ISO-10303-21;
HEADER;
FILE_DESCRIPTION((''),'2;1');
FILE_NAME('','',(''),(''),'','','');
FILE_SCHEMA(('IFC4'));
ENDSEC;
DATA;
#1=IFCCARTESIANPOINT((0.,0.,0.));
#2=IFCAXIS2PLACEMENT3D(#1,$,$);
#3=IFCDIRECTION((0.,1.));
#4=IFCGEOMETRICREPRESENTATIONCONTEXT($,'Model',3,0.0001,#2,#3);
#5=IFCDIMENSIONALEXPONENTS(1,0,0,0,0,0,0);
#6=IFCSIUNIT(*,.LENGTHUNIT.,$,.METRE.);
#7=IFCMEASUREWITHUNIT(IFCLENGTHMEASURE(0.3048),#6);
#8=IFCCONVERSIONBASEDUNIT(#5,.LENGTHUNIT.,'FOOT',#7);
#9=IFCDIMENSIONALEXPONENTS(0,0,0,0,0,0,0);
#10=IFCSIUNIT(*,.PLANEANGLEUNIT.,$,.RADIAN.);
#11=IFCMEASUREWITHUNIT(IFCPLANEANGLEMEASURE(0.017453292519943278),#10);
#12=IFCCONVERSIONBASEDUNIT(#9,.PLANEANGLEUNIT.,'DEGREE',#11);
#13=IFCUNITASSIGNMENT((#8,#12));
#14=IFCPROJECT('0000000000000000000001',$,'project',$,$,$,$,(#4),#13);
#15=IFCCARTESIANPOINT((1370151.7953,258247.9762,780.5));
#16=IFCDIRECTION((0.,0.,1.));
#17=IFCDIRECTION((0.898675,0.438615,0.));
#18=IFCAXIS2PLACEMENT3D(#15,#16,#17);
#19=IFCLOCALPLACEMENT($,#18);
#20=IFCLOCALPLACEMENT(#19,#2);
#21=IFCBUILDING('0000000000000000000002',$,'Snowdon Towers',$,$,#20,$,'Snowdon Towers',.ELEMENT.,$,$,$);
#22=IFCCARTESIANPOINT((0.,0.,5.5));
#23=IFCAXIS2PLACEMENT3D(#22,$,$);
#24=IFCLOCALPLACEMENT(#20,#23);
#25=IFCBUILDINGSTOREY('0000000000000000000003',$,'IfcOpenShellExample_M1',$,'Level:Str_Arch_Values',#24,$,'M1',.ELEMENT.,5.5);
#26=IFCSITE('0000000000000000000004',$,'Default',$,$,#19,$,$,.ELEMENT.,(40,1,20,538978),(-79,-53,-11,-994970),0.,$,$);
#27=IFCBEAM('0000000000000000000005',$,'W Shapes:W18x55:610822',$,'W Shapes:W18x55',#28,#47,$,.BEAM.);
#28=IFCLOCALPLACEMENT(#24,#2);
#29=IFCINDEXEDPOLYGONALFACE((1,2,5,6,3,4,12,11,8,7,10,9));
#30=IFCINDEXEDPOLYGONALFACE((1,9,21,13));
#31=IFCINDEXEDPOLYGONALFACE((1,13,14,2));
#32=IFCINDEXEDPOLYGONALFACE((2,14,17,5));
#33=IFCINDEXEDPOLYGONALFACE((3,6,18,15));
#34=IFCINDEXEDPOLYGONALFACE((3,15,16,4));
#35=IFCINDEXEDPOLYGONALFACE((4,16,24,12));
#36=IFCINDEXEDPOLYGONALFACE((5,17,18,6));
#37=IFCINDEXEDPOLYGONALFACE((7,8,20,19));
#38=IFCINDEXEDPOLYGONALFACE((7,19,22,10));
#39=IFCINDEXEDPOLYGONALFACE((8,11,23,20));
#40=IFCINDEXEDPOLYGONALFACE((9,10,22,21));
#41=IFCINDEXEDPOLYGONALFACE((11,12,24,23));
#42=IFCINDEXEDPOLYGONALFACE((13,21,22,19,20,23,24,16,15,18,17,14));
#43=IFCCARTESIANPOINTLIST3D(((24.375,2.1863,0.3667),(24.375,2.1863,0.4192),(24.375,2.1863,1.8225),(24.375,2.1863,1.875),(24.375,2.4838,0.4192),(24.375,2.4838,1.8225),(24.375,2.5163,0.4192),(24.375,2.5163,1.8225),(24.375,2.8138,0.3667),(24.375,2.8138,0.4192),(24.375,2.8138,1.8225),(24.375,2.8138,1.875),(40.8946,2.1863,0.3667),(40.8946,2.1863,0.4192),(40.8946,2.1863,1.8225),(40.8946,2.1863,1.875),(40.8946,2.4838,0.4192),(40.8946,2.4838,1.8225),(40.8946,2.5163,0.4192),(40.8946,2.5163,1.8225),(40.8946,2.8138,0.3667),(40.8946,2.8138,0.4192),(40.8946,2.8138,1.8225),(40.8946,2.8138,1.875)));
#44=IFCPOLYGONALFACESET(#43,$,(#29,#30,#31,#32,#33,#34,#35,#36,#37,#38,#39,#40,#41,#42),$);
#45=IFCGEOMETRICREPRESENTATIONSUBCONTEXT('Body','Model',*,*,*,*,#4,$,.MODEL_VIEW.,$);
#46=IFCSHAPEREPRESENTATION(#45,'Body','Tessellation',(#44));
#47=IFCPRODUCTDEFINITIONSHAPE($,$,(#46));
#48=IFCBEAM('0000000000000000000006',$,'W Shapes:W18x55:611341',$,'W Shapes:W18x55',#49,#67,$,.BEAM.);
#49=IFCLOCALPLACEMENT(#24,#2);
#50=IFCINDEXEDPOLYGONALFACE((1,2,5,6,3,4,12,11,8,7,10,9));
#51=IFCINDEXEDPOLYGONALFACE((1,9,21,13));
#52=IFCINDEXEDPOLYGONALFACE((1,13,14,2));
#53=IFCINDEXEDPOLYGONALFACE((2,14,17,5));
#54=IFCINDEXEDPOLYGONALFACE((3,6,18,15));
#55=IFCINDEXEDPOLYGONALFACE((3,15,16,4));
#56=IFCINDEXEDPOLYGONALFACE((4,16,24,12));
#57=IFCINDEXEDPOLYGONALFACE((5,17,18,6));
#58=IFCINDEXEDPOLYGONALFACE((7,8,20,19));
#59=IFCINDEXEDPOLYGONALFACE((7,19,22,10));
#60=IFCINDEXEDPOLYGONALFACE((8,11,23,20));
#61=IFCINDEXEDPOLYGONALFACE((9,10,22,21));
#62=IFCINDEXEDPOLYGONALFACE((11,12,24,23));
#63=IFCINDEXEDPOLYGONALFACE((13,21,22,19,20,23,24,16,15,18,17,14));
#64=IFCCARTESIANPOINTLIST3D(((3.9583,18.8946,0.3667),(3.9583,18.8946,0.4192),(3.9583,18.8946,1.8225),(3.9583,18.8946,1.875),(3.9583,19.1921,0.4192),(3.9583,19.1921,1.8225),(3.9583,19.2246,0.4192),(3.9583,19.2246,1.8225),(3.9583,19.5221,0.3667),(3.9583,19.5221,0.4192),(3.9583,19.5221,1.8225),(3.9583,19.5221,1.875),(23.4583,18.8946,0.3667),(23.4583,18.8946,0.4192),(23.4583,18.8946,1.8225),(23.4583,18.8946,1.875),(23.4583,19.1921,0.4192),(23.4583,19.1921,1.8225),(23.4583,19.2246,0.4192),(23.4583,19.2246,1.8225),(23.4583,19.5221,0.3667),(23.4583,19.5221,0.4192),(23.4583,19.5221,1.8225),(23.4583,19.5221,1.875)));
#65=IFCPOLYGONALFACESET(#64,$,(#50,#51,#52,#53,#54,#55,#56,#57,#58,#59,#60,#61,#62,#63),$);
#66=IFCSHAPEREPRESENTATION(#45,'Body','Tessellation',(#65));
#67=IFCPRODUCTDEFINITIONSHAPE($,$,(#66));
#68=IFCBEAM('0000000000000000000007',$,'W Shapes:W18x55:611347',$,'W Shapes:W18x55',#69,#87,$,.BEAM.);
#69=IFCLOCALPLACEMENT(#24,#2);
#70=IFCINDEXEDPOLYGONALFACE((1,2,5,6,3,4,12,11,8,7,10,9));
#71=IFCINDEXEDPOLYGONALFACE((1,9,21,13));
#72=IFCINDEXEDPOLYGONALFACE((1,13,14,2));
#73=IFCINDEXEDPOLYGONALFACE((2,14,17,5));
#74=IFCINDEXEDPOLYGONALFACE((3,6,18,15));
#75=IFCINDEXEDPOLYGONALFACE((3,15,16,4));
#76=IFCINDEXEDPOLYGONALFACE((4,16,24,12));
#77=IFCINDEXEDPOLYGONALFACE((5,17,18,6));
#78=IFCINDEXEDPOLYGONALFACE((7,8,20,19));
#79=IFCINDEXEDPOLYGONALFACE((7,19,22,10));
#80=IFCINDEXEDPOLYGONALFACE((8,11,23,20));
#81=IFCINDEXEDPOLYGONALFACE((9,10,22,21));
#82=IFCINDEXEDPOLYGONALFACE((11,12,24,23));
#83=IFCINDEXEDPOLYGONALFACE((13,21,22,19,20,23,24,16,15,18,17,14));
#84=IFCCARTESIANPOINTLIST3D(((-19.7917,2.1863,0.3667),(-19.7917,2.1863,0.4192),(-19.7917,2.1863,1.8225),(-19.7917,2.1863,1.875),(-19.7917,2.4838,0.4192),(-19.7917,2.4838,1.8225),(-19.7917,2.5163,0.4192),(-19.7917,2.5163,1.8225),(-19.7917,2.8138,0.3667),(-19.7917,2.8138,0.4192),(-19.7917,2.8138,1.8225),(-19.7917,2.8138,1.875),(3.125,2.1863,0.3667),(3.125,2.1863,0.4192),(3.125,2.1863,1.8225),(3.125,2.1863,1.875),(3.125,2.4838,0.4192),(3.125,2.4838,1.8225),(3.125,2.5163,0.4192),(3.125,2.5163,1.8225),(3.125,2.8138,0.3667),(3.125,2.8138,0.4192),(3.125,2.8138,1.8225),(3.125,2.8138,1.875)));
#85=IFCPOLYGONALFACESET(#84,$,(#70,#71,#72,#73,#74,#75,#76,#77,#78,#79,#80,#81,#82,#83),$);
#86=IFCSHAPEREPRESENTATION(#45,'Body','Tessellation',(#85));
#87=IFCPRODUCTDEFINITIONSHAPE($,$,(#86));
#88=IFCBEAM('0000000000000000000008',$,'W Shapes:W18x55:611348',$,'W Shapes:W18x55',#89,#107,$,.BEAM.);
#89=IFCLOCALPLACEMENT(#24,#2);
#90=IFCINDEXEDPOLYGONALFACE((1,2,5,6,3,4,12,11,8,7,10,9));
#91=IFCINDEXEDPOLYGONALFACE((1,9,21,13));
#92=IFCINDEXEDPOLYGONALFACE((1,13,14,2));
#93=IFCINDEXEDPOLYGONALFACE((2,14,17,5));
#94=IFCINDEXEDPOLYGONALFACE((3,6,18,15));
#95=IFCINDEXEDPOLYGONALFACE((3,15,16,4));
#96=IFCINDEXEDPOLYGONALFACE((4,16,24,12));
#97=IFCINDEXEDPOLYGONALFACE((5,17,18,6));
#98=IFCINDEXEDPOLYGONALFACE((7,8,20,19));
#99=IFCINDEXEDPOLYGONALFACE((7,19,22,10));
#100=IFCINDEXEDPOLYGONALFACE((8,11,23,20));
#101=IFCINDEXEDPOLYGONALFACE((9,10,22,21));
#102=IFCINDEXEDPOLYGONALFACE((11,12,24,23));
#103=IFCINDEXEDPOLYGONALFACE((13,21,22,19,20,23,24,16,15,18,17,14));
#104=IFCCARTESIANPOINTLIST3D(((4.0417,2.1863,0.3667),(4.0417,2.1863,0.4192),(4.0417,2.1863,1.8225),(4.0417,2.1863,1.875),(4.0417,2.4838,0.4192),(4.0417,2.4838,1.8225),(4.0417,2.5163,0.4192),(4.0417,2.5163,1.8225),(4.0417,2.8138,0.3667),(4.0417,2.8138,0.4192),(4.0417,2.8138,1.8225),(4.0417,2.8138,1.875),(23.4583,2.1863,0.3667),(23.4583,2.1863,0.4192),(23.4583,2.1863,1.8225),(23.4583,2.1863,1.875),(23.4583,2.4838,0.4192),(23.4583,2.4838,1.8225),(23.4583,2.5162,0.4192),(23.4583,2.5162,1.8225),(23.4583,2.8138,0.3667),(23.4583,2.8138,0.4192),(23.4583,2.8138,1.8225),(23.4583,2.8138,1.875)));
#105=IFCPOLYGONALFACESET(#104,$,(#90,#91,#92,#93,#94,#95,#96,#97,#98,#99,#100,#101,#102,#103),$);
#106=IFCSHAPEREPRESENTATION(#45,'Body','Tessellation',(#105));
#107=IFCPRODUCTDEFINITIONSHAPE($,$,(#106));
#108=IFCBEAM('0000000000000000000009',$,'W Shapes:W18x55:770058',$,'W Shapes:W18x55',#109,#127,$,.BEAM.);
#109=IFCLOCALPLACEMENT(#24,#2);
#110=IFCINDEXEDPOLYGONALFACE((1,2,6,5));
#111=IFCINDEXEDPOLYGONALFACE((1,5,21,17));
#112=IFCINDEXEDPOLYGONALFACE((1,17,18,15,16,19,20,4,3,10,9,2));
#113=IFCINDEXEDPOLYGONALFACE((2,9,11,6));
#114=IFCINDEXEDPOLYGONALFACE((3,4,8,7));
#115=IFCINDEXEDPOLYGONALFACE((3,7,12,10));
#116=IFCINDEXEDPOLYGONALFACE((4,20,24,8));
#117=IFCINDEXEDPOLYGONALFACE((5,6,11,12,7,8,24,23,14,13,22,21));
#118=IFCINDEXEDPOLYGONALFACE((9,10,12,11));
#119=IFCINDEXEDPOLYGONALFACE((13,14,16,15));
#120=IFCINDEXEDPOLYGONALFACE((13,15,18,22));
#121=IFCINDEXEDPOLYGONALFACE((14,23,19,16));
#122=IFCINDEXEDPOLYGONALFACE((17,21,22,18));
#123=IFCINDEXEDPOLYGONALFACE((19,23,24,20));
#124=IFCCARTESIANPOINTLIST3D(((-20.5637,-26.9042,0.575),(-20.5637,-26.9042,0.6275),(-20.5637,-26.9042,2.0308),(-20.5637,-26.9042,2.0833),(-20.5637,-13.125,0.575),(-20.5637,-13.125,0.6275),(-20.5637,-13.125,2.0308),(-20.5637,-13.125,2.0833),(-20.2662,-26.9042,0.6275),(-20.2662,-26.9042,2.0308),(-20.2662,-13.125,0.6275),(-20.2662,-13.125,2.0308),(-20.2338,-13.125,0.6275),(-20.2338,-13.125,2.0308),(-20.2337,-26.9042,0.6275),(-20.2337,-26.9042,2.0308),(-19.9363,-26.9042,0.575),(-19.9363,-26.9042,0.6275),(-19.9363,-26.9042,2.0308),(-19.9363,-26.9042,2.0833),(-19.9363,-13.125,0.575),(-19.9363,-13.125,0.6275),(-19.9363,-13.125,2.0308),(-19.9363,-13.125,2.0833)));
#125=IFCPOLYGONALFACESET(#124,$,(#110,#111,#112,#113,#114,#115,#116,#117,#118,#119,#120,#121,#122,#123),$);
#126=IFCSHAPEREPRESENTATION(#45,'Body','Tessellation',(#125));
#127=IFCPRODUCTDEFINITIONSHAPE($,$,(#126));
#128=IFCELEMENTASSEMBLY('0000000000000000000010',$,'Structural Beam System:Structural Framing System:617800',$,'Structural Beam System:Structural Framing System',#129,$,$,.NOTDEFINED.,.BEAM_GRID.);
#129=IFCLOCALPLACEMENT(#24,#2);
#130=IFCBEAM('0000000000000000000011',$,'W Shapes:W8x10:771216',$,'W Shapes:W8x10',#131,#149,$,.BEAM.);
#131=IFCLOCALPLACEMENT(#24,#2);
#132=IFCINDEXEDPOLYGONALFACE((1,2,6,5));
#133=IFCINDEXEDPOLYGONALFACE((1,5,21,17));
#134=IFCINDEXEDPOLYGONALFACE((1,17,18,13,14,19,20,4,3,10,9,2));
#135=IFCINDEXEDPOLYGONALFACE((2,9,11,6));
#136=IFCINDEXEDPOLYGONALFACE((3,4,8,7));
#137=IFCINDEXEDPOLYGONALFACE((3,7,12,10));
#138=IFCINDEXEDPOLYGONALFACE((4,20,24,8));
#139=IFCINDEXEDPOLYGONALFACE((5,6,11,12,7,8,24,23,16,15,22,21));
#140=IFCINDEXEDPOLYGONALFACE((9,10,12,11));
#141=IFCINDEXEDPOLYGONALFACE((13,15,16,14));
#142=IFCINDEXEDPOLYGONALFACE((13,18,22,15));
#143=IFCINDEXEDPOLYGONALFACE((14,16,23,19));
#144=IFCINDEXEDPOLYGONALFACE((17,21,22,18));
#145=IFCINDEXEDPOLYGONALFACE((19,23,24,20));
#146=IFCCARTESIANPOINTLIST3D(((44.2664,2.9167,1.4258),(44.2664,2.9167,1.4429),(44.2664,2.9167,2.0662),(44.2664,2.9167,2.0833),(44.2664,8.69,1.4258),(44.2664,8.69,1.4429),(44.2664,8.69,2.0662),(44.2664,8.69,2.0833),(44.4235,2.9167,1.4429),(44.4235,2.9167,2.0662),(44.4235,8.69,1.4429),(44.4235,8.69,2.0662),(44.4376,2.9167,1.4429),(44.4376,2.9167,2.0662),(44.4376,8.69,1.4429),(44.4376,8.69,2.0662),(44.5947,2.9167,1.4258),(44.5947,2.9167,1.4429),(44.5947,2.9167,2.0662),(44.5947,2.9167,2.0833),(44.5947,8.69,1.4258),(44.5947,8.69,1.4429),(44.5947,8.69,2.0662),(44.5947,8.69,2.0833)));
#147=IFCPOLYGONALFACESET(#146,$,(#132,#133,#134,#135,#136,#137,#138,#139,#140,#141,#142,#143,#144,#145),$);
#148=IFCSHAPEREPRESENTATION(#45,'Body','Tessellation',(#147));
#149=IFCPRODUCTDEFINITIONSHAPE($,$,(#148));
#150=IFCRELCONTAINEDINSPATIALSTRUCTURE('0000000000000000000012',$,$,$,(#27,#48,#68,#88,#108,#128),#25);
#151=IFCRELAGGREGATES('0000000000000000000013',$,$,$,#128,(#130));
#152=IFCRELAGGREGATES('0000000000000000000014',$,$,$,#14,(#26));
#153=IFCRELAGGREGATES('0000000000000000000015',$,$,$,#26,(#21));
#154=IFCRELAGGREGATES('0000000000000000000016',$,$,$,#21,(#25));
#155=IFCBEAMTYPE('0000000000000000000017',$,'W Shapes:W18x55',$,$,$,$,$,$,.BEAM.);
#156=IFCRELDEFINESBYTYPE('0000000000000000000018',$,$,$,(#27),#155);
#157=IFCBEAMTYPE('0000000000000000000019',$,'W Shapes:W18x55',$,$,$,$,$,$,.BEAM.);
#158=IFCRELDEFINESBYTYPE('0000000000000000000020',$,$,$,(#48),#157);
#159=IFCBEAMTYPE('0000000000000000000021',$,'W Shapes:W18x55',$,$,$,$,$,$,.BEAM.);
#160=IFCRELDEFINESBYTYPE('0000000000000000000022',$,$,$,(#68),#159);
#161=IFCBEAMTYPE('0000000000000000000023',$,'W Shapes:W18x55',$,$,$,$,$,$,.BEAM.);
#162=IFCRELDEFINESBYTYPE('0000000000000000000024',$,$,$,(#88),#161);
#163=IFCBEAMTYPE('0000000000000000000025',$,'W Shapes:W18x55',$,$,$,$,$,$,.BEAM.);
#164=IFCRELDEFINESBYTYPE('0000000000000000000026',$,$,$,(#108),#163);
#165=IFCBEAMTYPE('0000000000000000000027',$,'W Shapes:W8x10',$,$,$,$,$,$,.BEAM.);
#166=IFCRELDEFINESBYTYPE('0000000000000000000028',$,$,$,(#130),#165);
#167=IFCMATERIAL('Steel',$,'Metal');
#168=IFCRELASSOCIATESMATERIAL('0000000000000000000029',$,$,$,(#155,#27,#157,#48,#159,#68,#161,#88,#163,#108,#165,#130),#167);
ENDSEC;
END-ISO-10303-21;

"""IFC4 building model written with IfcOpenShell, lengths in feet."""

from ifc_helpers import new_model, entity, si_unit, converted_unit, direction, frame, origin, place, context, subcontext, project, spatial, indexed_curve, outline, extrude, source, transform, mapped, material, type_object, type_shapes, element, aggregate, save


model = new_model("IFC4")

# Units and contexts
model_context = context("Model", 3, precision=0.0001, world=origin(), true_north=direction((0.0, 1.0)))
body_context = subcontext(model_context, "Body", "Model", "MODEL_VIEW")
ifc_project = project(units=[converted_unit("LENGTHUNIT", "FOOT", entity("IfcLengthMeasure", 0.3048), si_unit("LENGTHUNIT", "METRE"), dimensions=[1, 0, 0, 0, 0, 0, 0]), converted_unit("PLANEANGLEUNIT", "DEGREE", entity("IfcPlaneAngleMeasure", 0.017453292519943278), si_unit("PLANEANGLEUNIT", "RADIAN"), dimensions=[0, 0, 0, 0, 0, 0, 0])], contexts=[model_context])

# Site, building, storey
site_placement = place(None, frame((1370151.7953, 258247.9762, 780.5), z_axis=(0.0, 0.0, 1.0), x_axis=(0.898675, 0.438615, 0.0)))
site = spatial("IfcSite", under=ifc_project, at=site_placement, Name="Default", CompositionType="ELEMENT", RefLatitude=(40, 1, 20, 538978), RefLongitude=(-79, -53, -11, -994970), RefElevation=0.0)
building_placement = place(site_placement, origin())
building = spatial("IfcBuilding", under=site, at=building_placement, Name="Snowdon Towers", LongName="Snowdon Towers", CompositionType="ELEMENT")
storey_placement = place(building_placement, frame((0.0, 0.0, 5.5)))
storey = spatial("IfcBuildingStorey", under=building, at=storey_placement, Name="IfcOpenShellExample_M1", ObjectType="Level:Str_Arch_Values", LongName="M1", CompositionType="ELEMENT", Elevation=5.5)

# Beams
ifc_material_1 = material(Name="Steel", Category="Metal")
beam_type_1 = type_object("IfcBeamType", Name="W Shapes:W18x55", PredefinedType="BEAM", material=ifc_material_1)
shared_shape_1 = source(origin(), body_context, "Body", "SweptSolid", [
    extrude(outline(indexed_curve([(-0.3138, -0.7017), (-0.3138, -0.7542), (0.3138, -0.7542), (0.3138, -0.7017), (0.0162, -0.7017), (0.0162, 0.7017), (0.3138, 0.7017), (0.3138, 0.7542), (-0.3137, 0.7542), (-0.3137, 0.7017), (-0.0163, 0.7017), (-0.0163, -0.7017), (-0.3138, -0.7017)], self_intersect=False)), frame((-8.2083, 0.0, 0.0), z_axis=(-1.0, 0.0, 0.0), x_axis=(0.0, -1.0, 0.0)), (0.0, 0.0, -1.0), 16.5196),
])
type_shapes(beam_type_1, [shared_shape_1])
beam_1_placement = place(storey_placement, frame((32.5833, 2.5, 1.1208)))
element("IfcBeam", 1, at=beam_1_placement, inside=storey, type_object=beam_type_1, material=ifc_material_1, Name="W Shapes:W18x55:610822", ObjectType="W Shapes:W18x55", PredefinedType="BEAM", context=body_context, shape_type="MappedRepresentation", body=[
    mapped(shared_shape_1, transform((0.0, 0.0, 0.0), scale=1.0)),
])
beam_type_2 = type_object("IfcBeamType", Name="W Shapes:W18x55", PredefinedType="BEAM", material=ifc_material_1)
shared_shape_2 = source(origin(), body_context, "Body", "SweptSolid", [
    extrude(outline(indexed_curve([(-0.3138, -0.7017), (-0.3138, -0.7542), (0.3138, -0.7542), (0.3138, -0.7017), (0.0162, -0.7017), (0.0162, 0.7017), (0.3138, 0.7017), (0.3138, 0.7542), (-0.3137, 0.7542), (-0.3137, 0.7017), (-0.0163, 0.7017), (-0.0163, -0.7017), (-0.3138, -0.7017)], self_intersect=False)), frame((-9.75, 0.0, 0.0), z_axis=(-1.0, 0.0, 0.0), x_axis=(0.0, -1.0, 0.0)), (0.0, 0.0, -1.0), 19.5),
])
type_shapes(beam_type_2, [shared_shape_2])
beam_2_placement = place(storey_placement, frame((13.7083, 19.2083, 1.1208)))
element("IfcBeam", 2, at=beam_2_placement, inside=storey, type_object=beam_type_2, material=ifc_material_1, Name="W Shapes:W18x55:611341", ObjectType="W Shapes:W18x55", PredefinedType="BEAM", context=body_context, shape_type="MappedRepresentation", body=[
    mapped(shared_shape_2, transform((0.0, 0.0, 0.0), scale=1.0)),
])
beam_type_3 = type_object("IfcBeamType", Name="W Shapes:W18x55", PredefinedType="BEAM", material=ifc_material_1)
shared_shape_3 = source(origin(), body_context, "Body", "SweptSolid", [
    extrude(outline(indexed_curve([(-0.3138, -0.7017), (-0.3138, -0.7542), (0.3138, -0.7542), (0.3138, -0.7017), (0.0162, -0.7017), (0.0162, 0.7017), (0.3138, 0.7017), (0.3138, 0.7542), (-0.3137, 0.7542), (-0.3137, 0.7017), (-0.0163, 0.7017), (-0.0163, -0.7017), (-0.3138, -0.7017)], self_intersect=False)), frame((-11.5417, 0.0, 0.0), z_axis=(-1.0, 0.0, 0.0), x_axis=(0.0, -1.0, 0.0)), (0.0, 0.0, -1.0), 22.9167),
])
type_shapes(beam_type_3, [shared_shape_3])
beam_3_placement = place(storey_placement, frame((-8.25, 2.5, 1.1208)))
element("IfcBeam", 3, at=beam_3_placement, inside=storey, type_object=beam_type_3, material=ifc_material_1, Name="W Shapes:W18x55:611347", ObjectType="W Shapes:W18x55", PredefinedType="BEAM", context=body_context, shape_type="MappedRepresentation", body=[
    mapped(shared_shape_3, transform((0.0, 0.0, 0.0), scale=1.0)),
])
beam_type_4 = type_object("IfcBeamType", Name="W Shapes:W18x55", PredefinedType="BEAM", material=ifc_material_1)
shared_shape_4 = source(origin(), body_context, "Body", "SweptSolid", [
    extrude(outline(indexed_curve([(-0.3138, -0.7017), (-0.3138, -0.7542), (0.3138, -0.7542), (0.3138, -0.7017), (0.0162, -0.7017), (0.0162, 0.7017), (0.3138, 0.7017), (0.3138, 0.7542), (-0.3137, 0.7542), (-0.3137, 0.7017), (-0.0163, 0.7017), (-0.0163, -0.7017), (-0.3138, -0.7017)], self_intersect=False)), frame((-9.7917, 0.0, 0.0), z_axis=(-1.0, 0.0, 0.0), x_axis=(0.0, -1.0, 0.0)), (0.0, 0.0, -1.0), 19.4167),
])
type_shapes(beam_type_4, [shared_shape_4])
beam_4_placement = place(storey_placement, frame((13.8333, 2.5, 1.1208)))
element("IfcBeam", 4, at=beam_4_placement, inside=storey, type_object=beam_type_4, material=ifc_material_1, Name="W Shapes:W18x55:611348", ObjectType="W Shapes:W18x55", PredefinedType="BEAM", context=body_context, shape_type="MappedRepresentation", body=[
    mapped(shared_shape_4, transform((0.0, 0.0, 0.0), scale=1.0)),
])
beam_type_5 = type_object("IfcBeamType", Name="W Shapes:W18x55", PredefinedType="BEAM", material=ifc_material_1)
shared_shape_5 = source(origin(), body_context, "Body", "SweptSolid", [
    extrude(outline(indexed_curve([(-0.3138, -0.7017), (-0.3138, -0.7542), (0.3138, -0.7542), (0.3138, -0.7017), (0.0162, -0.7017), (0.0162, 0.7017), (0.3138, 0.7017), (0.3138, 0.7542), (-0.3137, 0.7542), (-0.3137, 0.7017), (-0.0163, 0.7017), (-0.0163, -0.7017), (-0.3138, -0.7017)], self_intersect=False)), frame((-7.2292, 0.0, 0.0), z_axis=(-1.0, 0.0, 0.0), x_axis=(0.0, -1.0, 0.0)), (0.0, 0.0, -1.0), 13.7792),
])
type_shapes(beam_type_5, [shared_shape_5])
beam_5_placement = place(storey_placement, frame((-20.25, -20.3542, 1.3292), z_axis=(0.0, 0.0, 1.0), x_axis=(0.0, -1.0, 0.0)))
element("IfcBeam", 5, at=beam_5_placement, inside=storey, type_object=beam_type_5, material=ifc_material_1, Name="W Shapes:W18x55:770058", ObjectType="W Shapes:W18x55", PredefinedType="BEAM", context=body_context, shape_type="MappedRepresentation", body=[
    mapped(shared_shape_5, transform((0.0, 0.0, 0.0), scale=1.0)),
])

# Element assembly, beam
assembly_1_placement = place(storey_placement, origin())
assembly_1 = element("IfcElementAssembly", 6, at=assembly_1_placement, inside=storey, Name="Structural Beam System:Structural Framing System:617800", ObjectType="Structural Beam System:Structural Framing System", AssemblyPlace="NOTDEFINED", PredefinedType="BEAM_GRID")
beam_type_6 = type_object("IfcBeamType", Name="W Shapes:W8x10", PredefinedType="BEAM", material=ifc_material_1)
shared_shape_6 = source(origin(), body_context, "Body", "SweptSolid", [
    extrude(outline(indexed_curve([(-0.1642, -0.3117), (-0.1642, -0.3288), (0.1642, -0.3288), (0.1642, -0.3117), (0.0071, -0.3117), (0.0071, 0.3117), (0.1642, 0.3117), (0.1642, 0.3287), (-0.1642, 0.3287), (-0.1642, 0.3117), (-0.0071, 0.3117), (-0.0071, -0.3117), (-0.1642, -0.3117)], self_intersect=False)), frame((-3.0546, 0.0, 0.0), z_axis=(-1.0, 0.0, 0.0), x_axis=(0.0, -1.0, 0.0)), (0.0, 0.0, -1.0), 5.7733),
])
type_shapes(beam_type_6, [shared_shape_6])
beam_6_placement = place(assembly_1_placement, frame((44.4306, 5.6354, 1.7546), z_axis=(0.0, 0.0, 1.0), x_axis=(0.0, -1.0, 0.0)))
beam_6 = element("IfcBeam", 7, at=beam_6_placement, type_object=beam_type_6, material=ifc_material_1, Name="W Shapes:W8x10:771216", ObjectType="W Shapes:W8x10", PredefinedType="BEAM", context=body_context, shape_type="MappedRepresentation", body=[
    mapped(shared_shape_6, transform((0.0, 0.0, 0.0), scale=1.0)),
])
aggregate(assembly_1, [beam_6])

save(model, "model.ifc")
